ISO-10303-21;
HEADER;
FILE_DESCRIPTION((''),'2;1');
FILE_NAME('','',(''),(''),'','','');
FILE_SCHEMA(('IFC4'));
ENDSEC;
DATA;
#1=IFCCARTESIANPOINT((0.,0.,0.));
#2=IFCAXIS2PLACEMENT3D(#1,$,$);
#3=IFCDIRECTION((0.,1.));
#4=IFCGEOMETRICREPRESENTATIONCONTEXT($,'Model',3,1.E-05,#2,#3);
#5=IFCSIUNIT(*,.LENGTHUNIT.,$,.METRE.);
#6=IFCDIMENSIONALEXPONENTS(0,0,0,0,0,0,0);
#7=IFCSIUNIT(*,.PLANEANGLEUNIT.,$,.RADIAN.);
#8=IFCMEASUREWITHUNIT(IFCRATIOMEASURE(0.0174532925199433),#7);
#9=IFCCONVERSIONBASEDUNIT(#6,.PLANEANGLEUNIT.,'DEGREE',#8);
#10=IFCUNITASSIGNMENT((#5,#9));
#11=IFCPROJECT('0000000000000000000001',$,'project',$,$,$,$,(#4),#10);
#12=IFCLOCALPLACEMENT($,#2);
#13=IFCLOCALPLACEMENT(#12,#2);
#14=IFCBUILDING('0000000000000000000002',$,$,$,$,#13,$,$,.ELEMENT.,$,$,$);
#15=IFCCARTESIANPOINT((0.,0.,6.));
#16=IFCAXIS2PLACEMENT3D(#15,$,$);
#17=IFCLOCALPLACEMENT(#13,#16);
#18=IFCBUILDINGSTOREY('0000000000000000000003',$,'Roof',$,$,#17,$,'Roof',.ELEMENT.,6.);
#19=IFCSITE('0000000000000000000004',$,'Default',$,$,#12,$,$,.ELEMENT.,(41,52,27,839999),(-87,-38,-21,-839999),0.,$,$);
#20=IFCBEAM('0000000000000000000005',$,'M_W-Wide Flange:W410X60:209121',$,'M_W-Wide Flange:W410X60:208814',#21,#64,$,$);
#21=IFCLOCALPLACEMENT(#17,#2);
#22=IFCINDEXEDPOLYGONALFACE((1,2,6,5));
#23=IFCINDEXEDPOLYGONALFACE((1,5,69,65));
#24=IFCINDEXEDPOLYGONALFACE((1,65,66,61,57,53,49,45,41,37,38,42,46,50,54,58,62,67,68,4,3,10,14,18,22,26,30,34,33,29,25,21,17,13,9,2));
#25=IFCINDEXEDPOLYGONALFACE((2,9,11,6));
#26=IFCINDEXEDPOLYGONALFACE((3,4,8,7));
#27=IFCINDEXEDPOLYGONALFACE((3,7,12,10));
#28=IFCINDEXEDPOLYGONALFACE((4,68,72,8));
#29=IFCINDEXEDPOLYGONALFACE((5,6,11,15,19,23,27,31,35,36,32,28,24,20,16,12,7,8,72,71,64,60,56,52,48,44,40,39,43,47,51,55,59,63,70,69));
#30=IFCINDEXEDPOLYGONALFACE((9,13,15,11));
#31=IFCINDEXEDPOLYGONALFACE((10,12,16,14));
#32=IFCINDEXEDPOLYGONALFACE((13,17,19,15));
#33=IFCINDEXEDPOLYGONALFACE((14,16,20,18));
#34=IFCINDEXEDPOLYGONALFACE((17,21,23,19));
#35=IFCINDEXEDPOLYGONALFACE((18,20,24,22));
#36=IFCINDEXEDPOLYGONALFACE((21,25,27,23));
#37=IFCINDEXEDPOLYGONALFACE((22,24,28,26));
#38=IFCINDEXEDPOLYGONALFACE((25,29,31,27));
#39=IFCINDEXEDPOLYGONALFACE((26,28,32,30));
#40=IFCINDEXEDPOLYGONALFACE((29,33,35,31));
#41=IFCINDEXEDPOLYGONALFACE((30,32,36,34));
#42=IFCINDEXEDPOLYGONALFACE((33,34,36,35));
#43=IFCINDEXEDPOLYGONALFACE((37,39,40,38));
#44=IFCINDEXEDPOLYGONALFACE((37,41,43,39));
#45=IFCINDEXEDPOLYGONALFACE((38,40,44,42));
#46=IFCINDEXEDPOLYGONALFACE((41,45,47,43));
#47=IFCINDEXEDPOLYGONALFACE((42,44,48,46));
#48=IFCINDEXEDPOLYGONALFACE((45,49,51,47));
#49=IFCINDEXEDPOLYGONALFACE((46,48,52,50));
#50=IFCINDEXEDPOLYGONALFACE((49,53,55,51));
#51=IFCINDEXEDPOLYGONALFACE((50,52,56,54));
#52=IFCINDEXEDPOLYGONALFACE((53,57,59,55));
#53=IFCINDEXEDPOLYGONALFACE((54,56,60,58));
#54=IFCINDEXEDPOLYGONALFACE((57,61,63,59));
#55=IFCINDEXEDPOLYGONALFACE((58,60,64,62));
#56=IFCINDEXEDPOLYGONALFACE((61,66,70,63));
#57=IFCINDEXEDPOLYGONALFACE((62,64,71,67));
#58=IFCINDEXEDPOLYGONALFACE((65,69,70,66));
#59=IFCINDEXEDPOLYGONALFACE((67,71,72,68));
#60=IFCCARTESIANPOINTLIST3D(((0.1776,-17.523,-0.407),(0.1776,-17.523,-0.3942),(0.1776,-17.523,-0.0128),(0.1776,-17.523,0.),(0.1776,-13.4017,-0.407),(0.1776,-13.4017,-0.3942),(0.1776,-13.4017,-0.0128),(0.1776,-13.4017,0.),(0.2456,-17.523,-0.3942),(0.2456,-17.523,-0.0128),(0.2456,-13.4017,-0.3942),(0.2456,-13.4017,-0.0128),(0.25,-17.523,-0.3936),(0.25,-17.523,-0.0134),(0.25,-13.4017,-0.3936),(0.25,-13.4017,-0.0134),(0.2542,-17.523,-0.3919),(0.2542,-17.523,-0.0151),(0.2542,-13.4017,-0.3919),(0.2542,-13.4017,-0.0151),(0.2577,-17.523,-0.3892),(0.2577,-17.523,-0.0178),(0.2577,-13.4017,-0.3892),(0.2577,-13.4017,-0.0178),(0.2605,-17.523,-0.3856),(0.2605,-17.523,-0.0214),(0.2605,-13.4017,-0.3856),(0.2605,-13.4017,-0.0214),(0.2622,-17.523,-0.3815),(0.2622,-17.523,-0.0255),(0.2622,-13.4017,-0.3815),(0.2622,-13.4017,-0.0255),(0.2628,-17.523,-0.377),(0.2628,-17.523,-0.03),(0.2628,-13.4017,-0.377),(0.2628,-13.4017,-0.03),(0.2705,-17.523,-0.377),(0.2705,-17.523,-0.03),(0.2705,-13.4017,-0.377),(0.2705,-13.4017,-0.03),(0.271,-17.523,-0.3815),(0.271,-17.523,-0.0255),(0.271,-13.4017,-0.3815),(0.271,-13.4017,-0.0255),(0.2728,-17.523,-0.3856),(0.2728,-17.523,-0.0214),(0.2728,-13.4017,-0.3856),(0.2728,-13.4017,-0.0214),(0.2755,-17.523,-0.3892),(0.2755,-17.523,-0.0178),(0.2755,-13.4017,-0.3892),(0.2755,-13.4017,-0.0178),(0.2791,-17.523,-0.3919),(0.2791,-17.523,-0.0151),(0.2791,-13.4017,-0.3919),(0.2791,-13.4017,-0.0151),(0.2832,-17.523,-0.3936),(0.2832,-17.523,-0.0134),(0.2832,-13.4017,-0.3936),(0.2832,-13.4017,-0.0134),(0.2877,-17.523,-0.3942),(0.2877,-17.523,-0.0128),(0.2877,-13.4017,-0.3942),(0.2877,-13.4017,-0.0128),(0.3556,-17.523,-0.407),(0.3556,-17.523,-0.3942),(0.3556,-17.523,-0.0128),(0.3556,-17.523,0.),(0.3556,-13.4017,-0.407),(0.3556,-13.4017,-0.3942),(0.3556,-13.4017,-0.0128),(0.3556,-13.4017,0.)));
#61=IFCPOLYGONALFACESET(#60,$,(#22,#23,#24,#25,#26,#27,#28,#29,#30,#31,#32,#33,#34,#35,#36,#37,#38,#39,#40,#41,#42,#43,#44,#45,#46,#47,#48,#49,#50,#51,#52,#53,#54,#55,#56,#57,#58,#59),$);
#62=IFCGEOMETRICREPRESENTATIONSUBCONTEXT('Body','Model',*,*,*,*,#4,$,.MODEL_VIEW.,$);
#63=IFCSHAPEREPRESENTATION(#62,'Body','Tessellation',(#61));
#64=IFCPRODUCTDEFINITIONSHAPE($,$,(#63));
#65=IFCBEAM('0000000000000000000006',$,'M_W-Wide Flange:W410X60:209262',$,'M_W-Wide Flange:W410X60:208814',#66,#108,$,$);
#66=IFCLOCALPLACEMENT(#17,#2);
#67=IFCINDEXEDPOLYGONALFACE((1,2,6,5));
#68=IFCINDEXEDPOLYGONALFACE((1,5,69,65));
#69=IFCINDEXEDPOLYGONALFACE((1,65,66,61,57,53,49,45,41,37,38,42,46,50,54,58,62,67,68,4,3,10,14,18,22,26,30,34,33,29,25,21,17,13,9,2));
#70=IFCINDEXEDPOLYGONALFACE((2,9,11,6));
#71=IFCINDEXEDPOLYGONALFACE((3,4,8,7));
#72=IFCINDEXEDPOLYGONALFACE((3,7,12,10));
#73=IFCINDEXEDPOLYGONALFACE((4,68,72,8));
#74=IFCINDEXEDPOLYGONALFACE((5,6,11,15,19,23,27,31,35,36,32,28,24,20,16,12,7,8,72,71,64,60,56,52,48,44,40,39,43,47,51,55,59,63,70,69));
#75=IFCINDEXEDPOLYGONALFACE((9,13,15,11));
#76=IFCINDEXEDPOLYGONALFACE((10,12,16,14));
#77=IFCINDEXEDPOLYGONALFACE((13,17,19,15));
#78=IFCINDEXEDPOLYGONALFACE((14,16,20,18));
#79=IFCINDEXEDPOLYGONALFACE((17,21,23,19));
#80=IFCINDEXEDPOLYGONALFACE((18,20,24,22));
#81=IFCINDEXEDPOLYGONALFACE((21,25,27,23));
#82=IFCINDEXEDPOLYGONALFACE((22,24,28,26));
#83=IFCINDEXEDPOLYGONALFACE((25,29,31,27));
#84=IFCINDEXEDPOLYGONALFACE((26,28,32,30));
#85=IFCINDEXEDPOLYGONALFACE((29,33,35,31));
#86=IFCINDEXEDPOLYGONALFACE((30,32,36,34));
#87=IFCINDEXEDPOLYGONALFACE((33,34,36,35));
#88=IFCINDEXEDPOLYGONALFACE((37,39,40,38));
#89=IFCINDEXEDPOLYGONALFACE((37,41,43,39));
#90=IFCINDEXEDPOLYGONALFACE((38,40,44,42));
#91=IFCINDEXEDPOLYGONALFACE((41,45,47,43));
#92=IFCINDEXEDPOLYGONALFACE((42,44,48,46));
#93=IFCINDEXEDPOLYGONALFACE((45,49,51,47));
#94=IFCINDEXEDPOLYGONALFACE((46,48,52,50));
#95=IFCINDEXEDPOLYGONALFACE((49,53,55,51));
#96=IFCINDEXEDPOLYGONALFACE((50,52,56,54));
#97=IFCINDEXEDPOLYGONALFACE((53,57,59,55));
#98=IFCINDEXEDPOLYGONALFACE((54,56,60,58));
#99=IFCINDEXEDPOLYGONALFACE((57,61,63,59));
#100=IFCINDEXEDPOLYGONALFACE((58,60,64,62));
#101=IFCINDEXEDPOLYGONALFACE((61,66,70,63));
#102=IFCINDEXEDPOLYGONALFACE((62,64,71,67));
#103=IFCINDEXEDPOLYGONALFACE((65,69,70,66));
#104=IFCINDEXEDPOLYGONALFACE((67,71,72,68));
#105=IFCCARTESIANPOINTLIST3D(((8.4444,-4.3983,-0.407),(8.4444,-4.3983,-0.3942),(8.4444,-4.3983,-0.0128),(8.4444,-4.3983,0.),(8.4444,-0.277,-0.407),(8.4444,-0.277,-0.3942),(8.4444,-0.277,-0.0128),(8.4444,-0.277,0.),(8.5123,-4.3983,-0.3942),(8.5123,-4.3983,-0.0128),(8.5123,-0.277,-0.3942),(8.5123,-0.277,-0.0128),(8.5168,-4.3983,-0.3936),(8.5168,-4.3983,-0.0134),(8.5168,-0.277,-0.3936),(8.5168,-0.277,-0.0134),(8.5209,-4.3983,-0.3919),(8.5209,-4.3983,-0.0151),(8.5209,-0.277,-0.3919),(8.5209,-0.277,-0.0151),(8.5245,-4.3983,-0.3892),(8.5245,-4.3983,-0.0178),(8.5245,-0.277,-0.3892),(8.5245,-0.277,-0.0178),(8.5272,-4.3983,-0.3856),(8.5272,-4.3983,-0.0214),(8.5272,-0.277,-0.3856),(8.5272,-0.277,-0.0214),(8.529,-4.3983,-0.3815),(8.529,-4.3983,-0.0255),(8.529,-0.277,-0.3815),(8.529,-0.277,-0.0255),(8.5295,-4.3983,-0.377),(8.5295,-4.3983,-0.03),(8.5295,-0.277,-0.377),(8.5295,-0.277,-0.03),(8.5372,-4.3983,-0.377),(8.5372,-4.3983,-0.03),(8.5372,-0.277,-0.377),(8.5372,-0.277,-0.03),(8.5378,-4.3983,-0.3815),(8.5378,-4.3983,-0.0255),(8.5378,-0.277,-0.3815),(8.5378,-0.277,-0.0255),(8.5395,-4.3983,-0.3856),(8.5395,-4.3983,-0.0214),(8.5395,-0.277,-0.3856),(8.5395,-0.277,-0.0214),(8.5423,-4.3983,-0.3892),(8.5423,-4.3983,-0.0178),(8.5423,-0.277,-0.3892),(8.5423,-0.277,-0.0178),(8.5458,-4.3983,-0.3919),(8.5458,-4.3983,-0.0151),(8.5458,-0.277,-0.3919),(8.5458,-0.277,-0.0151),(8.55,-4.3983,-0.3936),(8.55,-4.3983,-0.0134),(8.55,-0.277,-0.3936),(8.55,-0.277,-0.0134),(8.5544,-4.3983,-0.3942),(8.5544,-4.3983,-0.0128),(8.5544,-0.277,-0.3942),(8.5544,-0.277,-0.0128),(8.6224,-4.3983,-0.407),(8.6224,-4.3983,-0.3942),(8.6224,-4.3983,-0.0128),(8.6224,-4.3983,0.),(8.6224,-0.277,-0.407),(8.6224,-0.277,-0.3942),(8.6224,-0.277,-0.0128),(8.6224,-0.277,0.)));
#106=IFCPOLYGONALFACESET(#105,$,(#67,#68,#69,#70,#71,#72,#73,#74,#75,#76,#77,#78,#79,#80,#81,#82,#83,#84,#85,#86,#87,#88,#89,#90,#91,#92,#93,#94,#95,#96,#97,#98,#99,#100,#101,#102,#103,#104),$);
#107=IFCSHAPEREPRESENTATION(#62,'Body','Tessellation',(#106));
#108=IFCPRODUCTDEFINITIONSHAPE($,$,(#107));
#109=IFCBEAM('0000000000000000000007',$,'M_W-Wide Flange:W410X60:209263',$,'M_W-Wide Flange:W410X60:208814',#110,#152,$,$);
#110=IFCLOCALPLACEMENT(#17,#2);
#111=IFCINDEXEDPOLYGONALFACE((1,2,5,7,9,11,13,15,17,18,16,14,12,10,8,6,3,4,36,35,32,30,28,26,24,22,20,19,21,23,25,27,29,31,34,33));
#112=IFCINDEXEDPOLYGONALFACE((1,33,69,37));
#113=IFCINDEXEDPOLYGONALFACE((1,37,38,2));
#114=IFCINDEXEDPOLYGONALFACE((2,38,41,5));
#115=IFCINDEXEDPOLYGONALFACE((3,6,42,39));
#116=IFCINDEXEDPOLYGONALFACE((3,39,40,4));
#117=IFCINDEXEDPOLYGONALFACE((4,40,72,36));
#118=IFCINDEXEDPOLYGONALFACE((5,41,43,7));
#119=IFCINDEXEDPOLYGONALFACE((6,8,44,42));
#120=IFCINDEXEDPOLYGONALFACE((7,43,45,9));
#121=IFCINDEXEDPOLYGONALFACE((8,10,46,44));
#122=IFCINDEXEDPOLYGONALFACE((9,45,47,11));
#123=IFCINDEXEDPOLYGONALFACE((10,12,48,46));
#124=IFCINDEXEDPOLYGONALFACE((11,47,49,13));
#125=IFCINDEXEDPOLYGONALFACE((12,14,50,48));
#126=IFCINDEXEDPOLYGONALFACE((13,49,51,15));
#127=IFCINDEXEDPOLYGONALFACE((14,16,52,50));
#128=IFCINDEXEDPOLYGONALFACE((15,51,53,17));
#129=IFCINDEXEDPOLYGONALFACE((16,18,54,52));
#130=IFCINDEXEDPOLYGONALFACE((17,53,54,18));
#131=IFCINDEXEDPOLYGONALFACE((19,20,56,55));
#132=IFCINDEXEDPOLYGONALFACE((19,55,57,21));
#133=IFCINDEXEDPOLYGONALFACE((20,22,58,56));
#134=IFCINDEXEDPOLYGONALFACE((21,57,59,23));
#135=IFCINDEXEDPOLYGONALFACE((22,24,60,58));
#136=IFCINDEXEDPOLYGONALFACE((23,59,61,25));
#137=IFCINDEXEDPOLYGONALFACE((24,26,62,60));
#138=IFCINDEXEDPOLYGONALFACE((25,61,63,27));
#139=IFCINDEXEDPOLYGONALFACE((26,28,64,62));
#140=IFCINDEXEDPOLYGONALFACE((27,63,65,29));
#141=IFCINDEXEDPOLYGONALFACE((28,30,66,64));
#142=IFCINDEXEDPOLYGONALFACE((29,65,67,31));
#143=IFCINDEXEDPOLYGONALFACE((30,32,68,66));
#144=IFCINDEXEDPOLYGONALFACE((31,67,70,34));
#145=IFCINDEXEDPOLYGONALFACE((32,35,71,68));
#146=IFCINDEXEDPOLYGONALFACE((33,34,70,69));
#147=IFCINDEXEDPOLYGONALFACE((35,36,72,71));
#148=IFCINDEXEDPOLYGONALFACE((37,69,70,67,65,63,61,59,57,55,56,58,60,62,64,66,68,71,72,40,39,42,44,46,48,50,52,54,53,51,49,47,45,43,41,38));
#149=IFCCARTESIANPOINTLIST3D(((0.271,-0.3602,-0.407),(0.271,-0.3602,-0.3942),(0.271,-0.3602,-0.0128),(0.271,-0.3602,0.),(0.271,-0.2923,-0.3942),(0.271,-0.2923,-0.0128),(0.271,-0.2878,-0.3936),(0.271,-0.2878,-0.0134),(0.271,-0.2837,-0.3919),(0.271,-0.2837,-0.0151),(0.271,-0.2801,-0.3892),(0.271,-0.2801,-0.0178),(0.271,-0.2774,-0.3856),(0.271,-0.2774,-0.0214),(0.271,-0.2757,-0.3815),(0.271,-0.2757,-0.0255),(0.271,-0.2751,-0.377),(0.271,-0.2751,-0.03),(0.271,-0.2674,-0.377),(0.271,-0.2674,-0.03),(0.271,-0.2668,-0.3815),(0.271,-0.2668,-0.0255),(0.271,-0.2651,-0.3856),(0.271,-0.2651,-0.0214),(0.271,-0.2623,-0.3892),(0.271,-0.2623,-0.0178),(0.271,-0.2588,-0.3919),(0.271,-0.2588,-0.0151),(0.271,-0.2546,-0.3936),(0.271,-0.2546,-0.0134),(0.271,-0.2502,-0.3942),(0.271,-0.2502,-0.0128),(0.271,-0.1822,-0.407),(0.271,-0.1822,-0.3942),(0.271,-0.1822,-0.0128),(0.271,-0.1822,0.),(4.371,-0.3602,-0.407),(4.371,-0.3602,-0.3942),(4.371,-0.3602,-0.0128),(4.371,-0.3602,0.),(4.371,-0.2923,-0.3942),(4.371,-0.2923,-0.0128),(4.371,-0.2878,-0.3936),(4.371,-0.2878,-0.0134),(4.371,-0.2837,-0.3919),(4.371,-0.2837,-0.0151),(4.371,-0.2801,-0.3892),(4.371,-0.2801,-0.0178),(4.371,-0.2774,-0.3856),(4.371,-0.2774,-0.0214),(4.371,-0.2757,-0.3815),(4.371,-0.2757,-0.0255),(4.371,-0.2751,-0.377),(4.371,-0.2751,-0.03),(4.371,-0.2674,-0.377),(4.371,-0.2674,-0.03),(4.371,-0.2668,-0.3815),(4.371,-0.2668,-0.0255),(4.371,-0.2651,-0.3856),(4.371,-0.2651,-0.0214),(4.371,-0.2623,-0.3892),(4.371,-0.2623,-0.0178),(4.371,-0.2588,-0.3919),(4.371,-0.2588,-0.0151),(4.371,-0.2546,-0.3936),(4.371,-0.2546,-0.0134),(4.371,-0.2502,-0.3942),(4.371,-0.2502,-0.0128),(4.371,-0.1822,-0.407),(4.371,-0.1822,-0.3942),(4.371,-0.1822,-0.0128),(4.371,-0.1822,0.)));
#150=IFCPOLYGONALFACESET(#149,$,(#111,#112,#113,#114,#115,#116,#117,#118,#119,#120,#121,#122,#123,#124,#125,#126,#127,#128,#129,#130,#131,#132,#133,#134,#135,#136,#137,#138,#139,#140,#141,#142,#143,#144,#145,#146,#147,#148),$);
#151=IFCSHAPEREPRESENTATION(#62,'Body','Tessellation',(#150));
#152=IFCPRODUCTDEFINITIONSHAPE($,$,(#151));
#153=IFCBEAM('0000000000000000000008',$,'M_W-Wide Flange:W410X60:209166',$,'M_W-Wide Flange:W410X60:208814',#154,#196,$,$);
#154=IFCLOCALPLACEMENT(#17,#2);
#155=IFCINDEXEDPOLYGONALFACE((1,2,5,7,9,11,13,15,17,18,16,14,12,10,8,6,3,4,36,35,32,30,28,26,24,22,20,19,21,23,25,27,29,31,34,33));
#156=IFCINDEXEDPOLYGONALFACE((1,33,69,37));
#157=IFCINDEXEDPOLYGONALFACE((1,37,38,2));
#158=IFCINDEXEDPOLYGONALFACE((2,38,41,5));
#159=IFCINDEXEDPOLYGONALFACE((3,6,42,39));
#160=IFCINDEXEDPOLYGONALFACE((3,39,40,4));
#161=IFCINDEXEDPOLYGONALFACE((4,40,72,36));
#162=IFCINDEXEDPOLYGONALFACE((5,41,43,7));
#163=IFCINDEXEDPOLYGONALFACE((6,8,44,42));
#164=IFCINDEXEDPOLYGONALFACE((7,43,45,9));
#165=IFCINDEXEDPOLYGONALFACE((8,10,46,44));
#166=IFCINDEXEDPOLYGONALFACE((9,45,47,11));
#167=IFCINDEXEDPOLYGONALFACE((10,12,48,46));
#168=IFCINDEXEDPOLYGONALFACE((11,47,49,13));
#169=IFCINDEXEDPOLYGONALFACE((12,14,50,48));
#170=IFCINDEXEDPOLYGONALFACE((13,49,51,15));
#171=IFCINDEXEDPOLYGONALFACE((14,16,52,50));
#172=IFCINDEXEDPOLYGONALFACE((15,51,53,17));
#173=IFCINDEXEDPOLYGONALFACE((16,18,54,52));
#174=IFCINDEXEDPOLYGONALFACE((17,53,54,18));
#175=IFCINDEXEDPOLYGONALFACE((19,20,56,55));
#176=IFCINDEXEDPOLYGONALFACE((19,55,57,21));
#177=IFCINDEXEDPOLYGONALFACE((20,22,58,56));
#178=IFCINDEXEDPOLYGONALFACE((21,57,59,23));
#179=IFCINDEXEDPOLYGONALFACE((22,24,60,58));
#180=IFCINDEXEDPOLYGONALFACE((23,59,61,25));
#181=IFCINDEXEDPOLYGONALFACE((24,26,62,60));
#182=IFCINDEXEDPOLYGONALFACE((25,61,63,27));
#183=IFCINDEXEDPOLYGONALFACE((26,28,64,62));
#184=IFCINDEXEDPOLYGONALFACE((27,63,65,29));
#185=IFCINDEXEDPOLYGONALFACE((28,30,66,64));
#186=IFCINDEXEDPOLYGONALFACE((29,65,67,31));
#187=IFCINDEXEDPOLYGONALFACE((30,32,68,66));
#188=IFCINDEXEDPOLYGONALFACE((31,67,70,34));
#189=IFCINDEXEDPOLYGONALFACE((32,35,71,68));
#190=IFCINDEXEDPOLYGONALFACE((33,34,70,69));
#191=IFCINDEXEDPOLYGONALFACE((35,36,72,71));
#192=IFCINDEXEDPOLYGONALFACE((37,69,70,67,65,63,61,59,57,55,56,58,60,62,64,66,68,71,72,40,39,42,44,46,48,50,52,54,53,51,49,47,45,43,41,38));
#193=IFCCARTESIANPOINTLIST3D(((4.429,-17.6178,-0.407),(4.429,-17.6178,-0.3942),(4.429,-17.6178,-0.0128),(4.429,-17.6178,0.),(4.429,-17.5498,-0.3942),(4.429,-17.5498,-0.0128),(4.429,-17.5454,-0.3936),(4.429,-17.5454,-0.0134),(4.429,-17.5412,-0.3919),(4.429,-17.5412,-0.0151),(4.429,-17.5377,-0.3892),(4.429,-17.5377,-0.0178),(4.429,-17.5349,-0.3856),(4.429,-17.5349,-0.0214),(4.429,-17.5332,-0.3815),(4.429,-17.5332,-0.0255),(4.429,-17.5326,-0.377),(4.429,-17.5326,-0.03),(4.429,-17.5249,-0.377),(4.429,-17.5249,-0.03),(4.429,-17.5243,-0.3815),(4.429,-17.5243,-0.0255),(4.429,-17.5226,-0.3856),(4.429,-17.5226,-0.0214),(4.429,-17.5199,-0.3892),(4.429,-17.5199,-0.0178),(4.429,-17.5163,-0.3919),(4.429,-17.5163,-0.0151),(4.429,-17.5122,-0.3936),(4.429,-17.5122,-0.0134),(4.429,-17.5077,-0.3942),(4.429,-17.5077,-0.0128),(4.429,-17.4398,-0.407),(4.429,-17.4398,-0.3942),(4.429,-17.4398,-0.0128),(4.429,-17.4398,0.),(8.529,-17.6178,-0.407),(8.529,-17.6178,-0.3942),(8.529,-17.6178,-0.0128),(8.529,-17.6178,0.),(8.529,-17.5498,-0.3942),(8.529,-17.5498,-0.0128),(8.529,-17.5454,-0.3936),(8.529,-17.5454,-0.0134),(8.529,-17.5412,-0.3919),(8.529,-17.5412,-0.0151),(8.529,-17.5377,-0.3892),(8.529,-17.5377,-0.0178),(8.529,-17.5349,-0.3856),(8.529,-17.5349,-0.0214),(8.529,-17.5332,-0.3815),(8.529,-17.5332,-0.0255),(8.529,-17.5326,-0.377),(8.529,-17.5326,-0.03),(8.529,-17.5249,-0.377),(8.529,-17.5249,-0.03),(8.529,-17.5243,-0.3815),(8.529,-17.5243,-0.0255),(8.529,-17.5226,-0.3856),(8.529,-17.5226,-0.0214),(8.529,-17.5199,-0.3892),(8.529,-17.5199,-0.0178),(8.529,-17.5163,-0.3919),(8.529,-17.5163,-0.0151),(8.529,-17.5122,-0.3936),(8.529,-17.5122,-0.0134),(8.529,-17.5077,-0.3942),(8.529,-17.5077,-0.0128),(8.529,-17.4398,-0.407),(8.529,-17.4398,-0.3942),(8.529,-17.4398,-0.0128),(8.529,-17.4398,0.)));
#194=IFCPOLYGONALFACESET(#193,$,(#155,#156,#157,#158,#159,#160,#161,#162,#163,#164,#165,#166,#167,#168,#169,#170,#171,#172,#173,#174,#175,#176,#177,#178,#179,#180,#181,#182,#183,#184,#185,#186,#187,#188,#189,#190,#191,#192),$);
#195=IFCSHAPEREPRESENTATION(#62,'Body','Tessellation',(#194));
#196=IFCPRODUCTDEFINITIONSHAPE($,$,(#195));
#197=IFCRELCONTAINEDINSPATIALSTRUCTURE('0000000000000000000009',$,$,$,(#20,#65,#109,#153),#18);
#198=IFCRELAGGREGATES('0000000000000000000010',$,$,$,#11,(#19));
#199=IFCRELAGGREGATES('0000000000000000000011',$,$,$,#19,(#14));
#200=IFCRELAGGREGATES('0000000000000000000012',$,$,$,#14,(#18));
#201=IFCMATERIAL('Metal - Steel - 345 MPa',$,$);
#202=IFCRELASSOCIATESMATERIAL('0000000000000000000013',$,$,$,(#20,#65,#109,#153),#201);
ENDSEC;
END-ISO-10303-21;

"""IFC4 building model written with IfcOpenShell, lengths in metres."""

from ifc_helpers import new_model, entity, si_unit, converted_unit, direction, frame, frame_2d, origin, place, context, subcontext, project, spatial, i_section, extrude, material, element, save


model = new_model("IFC4")

# Units and contexts
model_context = context("Model", 3, precision=1e-05, world=origin(), true_north=direction((0.0, 1.0)))
body_context = subcontext(model_context, "Body", "Model", "MODEL_VIEW")
ifc_project = project(units=[si_unit("LENGTHUNIT", "METRE"), converted_unit("PLANEANGLEUNIT", "DEGREE", entity("IfcRatioMeasure", 0.0174532925199433), si_unit("PLANEANGLEUNIT", "RADIAN"), dimensions=[0, 0, 0, 0, 0, 0, 0])], contexts=[model_context])

# Site, building, storey
site_placement = place(None, origin())
site = spatial("IfcSite", under=ifc_project, at=site_placement, Name="Default", CompositionType="ELEMENT", RefLatitude=(41, 52, 27, 839999), RefLongitude=(-87, -38, -21, -839999), RefElevation=0.0)
building_placement = place(site_placement, origin())
building = spatial("IfcBuilding", under=site, at=building_placement, CompositionType="ELEMENT")
storey_placement = place(building_placement, frame((0.0, 0.0, 6.0)))
storey = spatial("IfcBuildingStorey", under=building, at=storey_placement, Name="Roof", LongName="Roof", CompositionType="ELEMENT", Elevation=6.0)

# Beams
ifc_material_1 = material(Name="Metal - Steel - 345 MPa")
beam_1_placement = place(storey_placement, frame((0.2666, -13.4017, 0.0), z_axis=(0.0, 0.0, 1.0), x_axis=(0.0, -1.0, 0.0)))
element("IfcBeam", 1, at=beam_1_placement, inside=storey, material=ifc_material_1, Name="M_W-Wide Flange:W410X60:209121", ObjectType="M_W-Wide Flange:W410X60:208814", context=body_context, shape_type="SweptSolid", body=[
    extrude(i_section(OverallWidth=0.178, OverallDepth=0.407, WebThickness=0.0077, FlangeThickness=0.0128, FilletRadius=0.0172, at=frame_2d((0.0, 0.0), x_axis=(0.0, 1.0))), frame((0.0, 0.0, -0.2035), z_axis=(1.0, 0.0, 0.0), x_axis=(0.0, 0.0, -1.0)), (0.0, 0.0, 1.0), 4.1213),
])
beam_2_placement = place(storey_placement, frame((8.5334, -4.3983, 0.0), z_axis=(0.0, 0.0, 1.0), x_axis=(0.0, 1.0, 0.0)))
element("IfcBeam", 2, at=beam_2_placement, inside=storey, material=ifc_material_1, Name="M_W-Wide Flange:W410X60:209262", ObjectType="M_W-Wide Flange:W410X60:208814", context=body_context, shape_type="SweptSolid", body=[
    extrude(i_section(OverallWidth=0.178, OverallDepth=0.407, WebThickness=0.0077, FlangeThickness=0.0128, FilletRadius=0.0172, at=frame_2d((0.0, 0.0), x_axis=(0.0, 1.0))), frame((0.0, 0.0, -0.2035), z_axis=(1.0, 0.0, 0.0), x_axis=(0.0, 0.0, -1.0)), (0.0, 0.0, 1.0), 4.1213),
])
beam_3_placement = place(storey_placement, frame((4.371, -0.2712, 0.0), z_axis=(0.0, 0.0, 1.0), x_axis=(-1.0, 0.0, 0.0)))
element("IfcBeam", 3, at=beam_3_placement, inside=storey, material=ifc_material_1, Name="M_W-Wide Flange:W410X60:209263", ObjectType="M_W-Wide Flange:W410X60:208814", context=body_context, shape_type="SweptSolid", body=[
    extrude(i_section(OverallWidth=0.178, OverallDepth=0.407, WebThickness=0.0077, FlangeThickness=0.0128, FilletRadius=0.0172, at=frame_2d((0.0, 0.0), x_axis=(0.0, 1.0))), frame((0.0, 0.0, -0.2035), z_axis=(1.0, 0.0, 0.0), x_axis=(0.0, 0.0, -1.0)), (0.0, 0.0, 1.0), 4.1),
])
beam_4_placement = place(storey_placement, frame((4.429, -17.5288, 0.0)))
element("IfcBeam", 4, at=beam_4_placement, inside=storey, material=ifc_material_1, Name="M_W-Wide Flange:W410X60:209166", ObjectType="M_W-Wide Flange:W410X60:208814", context=body_context, shape_type="SweptSolid", body=[
    extrude(i_section(OverallWidth=0.178, OverallDepth=0.407, WebThickness=0.0077, FlangeThickness=0.0128, FilletRadius=0.0172, at=frame_2d((0.0, 0.0), x_axis=(0.0, 1.0))), frame((0.0, 0.0, -0.2035), z_axis=(1.0, 0.0, 0.0), x_axis=(0.0, 0.0, -1.0)), (0.0, 0.0, 1.0), 4.1),
])

save(model, "model.ifc")
